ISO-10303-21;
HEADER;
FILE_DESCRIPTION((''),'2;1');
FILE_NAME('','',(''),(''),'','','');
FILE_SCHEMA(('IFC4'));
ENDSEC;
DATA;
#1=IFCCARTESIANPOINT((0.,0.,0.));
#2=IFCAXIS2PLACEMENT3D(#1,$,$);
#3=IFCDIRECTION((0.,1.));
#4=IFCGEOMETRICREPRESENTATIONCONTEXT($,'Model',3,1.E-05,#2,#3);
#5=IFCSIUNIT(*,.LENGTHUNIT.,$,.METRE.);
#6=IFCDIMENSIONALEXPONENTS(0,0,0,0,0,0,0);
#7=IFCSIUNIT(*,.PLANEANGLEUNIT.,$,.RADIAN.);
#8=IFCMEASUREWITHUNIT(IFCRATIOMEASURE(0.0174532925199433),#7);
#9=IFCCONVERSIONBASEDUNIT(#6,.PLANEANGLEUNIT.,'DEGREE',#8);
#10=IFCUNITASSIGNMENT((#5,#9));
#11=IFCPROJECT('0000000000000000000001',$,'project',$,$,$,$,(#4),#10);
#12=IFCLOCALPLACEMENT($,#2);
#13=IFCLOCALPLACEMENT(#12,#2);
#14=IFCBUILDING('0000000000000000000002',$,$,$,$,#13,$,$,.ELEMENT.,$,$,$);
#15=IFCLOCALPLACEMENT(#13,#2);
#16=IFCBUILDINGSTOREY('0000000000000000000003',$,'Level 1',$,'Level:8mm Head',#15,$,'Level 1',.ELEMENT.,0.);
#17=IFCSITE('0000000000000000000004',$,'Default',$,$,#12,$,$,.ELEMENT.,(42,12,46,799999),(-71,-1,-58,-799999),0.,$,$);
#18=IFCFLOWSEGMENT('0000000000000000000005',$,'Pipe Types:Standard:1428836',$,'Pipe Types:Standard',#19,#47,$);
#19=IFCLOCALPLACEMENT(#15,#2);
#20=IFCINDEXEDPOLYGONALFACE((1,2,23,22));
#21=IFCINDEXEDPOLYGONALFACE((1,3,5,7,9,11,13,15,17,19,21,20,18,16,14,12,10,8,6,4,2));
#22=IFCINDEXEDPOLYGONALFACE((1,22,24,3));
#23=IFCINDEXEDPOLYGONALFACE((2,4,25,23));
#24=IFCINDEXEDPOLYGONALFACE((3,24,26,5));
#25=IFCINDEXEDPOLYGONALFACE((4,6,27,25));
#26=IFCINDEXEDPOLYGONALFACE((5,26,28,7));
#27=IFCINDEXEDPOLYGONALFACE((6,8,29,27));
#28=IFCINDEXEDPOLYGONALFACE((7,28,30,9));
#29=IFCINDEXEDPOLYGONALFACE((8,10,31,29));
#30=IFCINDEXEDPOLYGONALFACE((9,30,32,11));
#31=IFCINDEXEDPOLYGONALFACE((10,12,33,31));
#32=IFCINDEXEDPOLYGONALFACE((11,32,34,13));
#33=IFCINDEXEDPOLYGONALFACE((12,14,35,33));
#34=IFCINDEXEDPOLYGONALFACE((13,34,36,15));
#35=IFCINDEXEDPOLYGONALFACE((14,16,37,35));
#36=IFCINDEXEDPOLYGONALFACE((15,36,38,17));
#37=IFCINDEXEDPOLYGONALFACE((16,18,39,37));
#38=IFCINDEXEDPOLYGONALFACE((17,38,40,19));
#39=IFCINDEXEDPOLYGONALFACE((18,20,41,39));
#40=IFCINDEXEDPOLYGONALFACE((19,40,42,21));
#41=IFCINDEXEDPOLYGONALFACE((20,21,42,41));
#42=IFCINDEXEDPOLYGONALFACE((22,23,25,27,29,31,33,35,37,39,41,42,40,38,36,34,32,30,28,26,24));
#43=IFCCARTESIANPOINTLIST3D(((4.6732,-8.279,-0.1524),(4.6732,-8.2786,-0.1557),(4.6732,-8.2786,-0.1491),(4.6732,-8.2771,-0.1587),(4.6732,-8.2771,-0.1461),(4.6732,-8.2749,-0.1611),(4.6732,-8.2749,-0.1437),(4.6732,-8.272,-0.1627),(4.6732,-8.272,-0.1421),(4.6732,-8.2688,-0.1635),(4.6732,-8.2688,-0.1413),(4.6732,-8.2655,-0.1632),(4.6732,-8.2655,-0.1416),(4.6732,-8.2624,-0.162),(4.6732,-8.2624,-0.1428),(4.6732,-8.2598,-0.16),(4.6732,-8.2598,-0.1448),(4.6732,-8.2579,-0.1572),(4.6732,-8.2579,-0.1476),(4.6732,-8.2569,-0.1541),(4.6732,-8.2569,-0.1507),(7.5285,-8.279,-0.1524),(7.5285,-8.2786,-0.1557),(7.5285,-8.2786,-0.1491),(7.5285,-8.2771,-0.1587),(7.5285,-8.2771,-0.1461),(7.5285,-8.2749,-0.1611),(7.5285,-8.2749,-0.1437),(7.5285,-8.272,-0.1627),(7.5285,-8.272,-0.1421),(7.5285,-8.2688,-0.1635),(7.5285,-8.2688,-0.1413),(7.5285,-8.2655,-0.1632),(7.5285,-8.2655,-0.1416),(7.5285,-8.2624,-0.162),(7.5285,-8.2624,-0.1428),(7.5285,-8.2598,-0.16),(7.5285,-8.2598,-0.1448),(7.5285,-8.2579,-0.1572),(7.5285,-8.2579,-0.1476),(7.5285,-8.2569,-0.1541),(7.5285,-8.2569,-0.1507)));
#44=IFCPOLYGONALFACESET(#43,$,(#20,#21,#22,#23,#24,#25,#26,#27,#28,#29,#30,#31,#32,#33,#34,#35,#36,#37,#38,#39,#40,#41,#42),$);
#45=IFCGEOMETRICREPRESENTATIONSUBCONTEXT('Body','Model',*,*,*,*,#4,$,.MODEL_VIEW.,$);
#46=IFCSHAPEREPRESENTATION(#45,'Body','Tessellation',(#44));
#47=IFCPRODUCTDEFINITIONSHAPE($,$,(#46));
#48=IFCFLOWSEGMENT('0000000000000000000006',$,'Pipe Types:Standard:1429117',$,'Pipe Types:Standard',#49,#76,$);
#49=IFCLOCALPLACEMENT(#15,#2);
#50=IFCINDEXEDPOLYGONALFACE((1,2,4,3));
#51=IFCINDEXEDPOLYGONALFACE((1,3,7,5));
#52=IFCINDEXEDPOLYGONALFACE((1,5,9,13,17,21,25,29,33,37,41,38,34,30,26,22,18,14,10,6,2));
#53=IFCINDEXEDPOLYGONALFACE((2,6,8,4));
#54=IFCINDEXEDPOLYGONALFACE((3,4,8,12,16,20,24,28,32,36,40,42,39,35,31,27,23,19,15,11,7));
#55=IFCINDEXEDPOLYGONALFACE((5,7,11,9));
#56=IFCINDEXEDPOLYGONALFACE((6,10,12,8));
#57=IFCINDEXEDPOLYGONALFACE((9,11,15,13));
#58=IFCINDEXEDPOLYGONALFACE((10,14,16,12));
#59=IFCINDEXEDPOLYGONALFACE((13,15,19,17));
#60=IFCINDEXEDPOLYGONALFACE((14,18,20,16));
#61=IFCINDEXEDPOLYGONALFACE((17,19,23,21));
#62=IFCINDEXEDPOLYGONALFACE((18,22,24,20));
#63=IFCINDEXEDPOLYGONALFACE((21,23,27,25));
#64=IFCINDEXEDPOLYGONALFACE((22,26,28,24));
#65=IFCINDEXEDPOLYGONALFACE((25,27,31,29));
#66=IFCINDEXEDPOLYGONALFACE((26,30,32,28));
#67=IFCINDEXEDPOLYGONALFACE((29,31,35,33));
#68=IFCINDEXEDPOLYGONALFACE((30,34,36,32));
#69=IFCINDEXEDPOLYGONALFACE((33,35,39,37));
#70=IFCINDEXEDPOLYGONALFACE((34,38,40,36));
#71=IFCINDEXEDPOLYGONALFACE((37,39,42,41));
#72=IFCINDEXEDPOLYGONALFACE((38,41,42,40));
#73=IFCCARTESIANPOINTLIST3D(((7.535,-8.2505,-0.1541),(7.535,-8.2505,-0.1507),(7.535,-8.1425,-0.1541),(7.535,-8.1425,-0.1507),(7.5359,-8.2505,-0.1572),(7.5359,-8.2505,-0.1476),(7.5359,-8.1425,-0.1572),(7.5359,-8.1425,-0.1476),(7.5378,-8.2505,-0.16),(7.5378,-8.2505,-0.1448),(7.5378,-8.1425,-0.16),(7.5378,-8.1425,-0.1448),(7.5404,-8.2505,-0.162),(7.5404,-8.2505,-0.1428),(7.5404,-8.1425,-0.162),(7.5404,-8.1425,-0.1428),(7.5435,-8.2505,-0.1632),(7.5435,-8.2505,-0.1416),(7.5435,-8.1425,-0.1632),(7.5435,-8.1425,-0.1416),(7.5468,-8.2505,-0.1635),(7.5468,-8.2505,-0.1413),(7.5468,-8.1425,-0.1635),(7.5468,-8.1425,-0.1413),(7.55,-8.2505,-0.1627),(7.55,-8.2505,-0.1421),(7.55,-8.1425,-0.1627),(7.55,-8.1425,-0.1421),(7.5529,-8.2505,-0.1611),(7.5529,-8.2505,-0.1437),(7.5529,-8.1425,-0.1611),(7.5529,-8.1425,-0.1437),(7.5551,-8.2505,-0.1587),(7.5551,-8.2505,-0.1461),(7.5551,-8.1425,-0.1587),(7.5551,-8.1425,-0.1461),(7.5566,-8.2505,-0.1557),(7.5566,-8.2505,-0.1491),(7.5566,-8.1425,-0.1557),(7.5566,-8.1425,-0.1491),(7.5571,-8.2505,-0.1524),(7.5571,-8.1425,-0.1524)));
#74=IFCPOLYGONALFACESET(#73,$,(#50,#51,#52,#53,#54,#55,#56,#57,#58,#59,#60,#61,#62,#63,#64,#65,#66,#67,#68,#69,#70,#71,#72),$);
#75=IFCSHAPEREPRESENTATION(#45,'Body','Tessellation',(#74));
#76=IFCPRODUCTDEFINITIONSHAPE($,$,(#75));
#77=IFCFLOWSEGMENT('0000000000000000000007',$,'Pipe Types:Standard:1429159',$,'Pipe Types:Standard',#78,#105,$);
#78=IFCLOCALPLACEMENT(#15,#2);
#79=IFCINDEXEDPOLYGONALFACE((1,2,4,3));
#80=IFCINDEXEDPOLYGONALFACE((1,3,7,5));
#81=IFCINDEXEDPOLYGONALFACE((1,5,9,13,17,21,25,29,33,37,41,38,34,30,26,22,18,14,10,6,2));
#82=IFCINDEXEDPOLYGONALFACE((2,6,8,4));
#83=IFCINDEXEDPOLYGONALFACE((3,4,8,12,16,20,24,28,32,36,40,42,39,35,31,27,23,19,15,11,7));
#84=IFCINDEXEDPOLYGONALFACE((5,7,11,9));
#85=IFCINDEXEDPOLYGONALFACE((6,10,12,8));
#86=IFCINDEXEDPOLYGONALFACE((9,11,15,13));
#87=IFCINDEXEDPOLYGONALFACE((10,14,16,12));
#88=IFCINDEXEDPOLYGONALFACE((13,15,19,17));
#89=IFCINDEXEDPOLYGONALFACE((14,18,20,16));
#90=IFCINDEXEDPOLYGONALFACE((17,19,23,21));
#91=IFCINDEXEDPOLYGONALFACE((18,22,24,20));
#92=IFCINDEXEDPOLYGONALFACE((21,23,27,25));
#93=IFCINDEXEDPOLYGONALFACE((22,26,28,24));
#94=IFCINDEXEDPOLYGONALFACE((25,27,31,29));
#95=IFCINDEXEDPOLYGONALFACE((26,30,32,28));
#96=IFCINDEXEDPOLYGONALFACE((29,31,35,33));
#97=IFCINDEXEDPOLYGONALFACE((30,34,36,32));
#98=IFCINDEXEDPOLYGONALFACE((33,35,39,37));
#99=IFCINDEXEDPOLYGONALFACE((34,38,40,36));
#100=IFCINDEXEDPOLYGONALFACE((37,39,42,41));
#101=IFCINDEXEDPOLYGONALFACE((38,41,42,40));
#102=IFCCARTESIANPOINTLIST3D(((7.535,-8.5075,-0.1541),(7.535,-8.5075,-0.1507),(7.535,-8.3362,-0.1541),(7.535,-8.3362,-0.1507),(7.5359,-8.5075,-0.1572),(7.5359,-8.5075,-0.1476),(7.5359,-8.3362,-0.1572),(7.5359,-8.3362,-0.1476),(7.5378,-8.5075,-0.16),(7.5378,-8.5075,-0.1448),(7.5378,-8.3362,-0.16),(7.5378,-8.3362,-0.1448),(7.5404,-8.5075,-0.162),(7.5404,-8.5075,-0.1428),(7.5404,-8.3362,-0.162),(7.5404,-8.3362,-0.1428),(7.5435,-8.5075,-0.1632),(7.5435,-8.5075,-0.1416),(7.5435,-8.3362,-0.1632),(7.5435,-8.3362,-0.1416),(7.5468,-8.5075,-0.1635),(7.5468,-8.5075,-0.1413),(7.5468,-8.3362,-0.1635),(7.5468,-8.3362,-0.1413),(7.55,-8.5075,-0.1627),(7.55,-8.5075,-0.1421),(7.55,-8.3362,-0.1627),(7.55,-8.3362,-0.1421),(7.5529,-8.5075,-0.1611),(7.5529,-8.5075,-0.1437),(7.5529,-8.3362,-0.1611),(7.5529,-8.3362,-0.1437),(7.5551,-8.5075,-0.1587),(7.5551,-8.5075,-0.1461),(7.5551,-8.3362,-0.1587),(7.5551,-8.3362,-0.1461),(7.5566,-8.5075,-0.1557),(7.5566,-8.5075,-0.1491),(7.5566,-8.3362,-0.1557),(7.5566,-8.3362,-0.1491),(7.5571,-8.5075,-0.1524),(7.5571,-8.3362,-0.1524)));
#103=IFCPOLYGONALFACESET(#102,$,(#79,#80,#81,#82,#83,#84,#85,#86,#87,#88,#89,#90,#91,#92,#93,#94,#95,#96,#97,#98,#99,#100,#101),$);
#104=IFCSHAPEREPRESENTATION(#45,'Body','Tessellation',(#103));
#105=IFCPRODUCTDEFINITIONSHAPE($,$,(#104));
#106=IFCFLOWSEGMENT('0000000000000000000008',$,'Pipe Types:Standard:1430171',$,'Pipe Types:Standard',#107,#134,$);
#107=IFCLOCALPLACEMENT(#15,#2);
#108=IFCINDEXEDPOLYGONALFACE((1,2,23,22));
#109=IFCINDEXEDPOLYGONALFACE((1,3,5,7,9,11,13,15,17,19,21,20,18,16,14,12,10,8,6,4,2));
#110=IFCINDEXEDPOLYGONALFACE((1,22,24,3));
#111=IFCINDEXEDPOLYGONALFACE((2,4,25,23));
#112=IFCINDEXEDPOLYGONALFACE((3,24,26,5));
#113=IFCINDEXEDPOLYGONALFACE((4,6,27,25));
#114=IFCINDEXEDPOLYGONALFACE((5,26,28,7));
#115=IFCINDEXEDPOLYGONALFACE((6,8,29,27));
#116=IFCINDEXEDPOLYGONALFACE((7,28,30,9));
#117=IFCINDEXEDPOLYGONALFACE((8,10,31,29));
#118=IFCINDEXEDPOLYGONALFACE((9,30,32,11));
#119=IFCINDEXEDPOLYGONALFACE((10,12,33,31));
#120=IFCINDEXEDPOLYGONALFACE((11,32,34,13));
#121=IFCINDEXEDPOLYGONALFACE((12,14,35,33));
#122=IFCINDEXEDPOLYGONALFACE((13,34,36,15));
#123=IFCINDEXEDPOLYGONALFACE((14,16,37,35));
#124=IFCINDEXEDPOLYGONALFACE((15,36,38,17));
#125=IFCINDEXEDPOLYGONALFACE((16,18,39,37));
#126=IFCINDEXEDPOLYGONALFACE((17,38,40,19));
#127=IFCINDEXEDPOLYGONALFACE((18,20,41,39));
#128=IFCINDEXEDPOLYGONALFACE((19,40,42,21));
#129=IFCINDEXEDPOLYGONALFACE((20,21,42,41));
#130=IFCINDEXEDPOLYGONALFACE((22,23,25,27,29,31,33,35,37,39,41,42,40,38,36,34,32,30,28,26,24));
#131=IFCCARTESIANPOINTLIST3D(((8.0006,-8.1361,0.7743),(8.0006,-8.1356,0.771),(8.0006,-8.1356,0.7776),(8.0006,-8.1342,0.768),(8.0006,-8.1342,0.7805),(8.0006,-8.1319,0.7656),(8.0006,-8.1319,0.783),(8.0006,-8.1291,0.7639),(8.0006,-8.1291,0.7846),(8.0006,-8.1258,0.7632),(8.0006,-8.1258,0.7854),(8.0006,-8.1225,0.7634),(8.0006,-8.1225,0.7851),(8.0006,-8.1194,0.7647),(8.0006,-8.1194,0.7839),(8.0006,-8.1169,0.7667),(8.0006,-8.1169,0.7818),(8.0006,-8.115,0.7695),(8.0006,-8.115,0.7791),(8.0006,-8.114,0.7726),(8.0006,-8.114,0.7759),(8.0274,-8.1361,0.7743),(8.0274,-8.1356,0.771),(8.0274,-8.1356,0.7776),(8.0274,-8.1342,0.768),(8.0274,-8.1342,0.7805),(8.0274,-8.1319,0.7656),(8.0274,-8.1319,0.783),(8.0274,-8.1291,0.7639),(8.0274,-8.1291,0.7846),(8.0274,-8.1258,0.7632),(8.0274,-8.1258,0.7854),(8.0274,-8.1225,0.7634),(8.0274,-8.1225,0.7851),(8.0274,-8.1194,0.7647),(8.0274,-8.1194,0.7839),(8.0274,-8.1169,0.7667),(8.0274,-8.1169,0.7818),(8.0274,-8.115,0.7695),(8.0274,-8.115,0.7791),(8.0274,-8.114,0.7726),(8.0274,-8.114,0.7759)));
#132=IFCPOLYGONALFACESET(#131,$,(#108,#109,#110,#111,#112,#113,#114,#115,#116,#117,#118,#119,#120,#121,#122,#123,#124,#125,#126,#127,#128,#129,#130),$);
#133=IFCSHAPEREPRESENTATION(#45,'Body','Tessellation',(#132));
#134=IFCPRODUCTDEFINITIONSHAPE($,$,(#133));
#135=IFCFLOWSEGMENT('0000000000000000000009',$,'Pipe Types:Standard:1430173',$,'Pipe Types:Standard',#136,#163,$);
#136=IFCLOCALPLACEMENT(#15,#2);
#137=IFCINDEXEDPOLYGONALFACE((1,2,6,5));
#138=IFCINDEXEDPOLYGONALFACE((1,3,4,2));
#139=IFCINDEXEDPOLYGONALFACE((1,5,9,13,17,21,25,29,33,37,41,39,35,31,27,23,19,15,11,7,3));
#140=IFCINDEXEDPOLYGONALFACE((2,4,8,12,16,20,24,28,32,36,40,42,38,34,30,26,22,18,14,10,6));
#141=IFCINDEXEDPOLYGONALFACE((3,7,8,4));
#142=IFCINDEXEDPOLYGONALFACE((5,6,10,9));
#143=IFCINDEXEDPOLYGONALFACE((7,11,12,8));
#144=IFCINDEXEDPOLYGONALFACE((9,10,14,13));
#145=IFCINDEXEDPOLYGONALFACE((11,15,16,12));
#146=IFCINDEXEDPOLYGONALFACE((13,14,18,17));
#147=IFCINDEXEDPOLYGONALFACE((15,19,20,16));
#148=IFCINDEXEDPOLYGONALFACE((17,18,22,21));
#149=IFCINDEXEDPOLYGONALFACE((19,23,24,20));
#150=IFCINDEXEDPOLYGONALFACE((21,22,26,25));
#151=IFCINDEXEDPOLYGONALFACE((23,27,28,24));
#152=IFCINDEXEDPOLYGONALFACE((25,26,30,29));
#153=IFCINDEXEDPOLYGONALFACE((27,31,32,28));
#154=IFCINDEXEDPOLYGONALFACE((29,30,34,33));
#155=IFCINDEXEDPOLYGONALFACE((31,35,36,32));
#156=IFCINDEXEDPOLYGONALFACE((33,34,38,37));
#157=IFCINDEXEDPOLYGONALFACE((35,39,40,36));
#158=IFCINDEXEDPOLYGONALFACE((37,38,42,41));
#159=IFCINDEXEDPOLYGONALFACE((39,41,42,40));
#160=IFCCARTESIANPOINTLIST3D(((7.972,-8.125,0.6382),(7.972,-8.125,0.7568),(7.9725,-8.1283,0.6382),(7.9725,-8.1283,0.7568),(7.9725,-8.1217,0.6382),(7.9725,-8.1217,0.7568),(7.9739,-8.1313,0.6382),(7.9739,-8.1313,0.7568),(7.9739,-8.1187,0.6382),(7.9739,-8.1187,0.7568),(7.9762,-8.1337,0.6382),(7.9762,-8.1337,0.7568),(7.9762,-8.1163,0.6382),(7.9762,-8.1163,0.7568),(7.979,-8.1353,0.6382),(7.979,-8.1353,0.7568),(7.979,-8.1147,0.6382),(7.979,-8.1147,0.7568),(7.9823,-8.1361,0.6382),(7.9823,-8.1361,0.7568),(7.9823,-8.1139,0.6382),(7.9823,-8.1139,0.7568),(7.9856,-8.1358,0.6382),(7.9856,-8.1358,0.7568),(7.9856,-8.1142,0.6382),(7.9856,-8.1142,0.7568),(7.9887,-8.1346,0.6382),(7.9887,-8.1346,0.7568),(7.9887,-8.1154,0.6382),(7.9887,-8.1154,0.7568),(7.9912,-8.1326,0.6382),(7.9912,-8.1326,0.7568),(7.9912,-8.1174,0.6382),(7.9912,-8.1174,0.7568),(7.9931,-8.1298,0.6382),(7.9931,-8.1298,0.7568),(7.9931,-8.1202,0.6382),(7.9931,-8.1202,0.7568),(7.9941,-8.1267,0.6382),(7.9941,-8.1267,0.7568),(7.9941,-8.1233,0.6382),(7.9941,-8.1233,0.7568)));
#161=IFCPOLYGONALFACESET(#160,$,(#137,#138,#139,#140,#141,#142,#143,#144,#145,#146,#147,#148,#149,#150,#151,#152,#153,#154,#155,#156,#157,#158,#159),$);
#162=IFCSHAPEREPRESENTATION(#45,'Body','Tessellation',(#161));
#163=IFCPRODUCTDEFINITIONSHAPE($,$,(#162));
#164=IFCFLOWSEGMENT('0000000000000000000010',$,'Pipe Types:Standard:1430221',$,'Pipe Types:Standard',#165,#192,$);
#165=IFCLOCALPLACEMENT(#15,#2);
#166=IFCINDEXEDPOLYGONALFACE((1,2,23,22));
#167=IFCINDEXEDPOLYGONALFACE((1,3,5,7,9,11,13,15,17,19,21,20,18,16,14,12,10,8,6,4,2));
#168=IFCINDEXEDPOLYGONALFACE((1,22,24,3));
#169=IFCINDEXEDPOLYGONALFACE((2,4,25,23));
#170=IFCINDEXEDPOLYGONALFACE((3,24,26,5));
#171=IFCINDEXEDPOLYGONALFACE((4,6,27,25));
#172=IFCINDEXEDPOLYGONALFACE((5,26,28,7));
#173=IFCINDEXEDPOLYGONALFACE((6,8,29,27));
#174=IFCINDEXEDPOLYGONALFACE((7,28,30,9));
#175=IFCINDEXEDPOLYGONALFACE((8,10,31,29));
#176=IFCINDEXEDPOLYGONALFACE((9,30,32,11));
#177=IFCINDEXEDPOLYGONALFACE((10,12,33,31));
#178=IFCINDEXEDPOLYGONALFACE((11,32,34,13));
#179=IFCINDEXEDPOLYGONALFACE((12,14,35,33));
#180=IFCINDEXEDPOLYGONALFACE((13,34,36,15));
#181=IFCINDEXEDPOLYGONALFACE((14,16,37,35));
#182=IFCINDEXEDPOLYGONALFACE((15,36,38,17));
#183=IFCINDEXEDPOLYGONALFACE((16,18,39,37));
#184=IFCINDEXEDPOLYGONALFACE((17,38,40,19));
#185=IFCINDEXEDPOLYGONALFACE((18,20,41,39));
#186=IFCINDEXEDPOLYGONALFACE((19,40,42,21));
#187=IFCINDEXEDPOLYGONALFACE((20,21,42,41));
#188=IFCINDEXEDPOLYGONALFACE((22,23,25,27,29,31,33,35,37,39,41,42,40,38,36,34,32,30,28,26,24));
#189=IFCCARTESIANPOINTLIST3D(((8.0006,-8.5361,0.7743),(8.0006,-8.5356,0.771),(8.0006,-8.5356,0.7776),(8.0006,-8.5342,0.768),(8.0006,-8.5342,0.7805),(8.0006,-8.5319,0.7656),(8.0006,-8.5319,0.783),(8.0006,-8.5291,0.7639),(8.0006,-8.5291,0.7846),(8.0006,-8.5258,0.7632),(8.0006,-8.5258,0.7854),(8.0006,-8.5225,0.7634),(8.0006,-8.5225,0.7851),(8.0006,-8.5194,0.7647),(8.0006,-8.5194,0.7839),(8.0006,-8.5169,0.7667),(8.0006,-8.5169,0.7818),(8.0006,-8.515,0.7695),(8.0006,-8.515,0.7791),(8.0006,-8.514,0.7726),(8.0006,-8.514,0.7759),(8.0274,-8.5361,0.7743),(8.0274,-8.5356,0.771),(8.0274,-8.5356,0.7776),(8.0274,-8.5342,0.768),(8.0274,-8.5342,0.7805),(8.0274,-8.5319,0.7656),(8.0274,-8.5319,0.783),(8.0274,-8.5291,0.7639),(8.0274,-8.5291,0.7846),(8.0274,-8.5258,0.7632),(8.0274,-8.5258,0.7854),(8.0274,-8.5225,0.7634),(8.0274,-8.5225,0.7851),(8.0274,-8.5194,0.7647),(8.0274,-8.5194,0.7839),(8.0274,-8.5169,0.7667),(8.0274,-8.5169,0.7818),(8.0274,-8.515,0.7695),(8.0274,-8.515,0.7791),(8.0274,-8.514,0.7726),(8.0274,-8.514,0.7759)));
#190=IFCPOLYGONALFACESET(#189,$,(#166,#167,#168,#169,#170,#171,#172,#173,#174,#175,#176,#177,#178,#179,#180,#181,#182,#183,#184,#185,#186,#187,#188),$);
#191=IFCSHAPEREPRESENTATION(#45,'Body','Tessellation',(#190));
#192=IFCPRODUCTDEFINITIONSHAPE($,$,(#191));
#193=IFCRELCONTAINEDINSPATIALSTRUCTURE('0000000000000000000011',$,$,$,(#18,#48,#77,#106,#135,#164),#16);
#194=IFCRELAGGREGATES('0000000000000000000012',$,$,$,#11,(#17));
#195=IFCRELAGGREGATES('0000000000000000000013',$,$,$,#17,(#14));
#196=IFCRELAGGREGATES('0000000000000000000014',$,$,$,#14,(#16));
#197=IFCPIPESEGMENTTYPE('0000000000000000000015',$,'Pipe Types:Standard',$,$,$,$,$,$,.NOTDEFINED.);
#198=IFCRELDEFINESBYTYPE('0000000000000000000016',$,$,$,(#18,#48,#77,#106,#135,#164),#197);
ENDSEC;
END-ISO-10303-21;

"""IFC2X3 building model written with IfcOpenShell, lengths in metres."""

from ifc_helpers import new_model, entity, si_unit, converted_unit, direction, frame, frame_2d, origin, origin_2d_with_axis, place, context, subcontext, project, spatial, circle, extrude, type_object, element, save


model = new_model("IFC2X3")

# Units and contexts
model_context = context("Model", 3, precision=1e-05, world=origin(), true_north=direction((0.0, 1.0)))
body_context = subcontext(model_context, "Body", "Model", "MODEL_VIEW")
ifc_project = project(units=[si_unit("LENGTHUNIT", "METRE"), converted_unit("PLANEANGLEUNIT", "DEGREE", entity("IfcRatioMeasure", 0.0174532925199433), si_unit("PLANEANGLEUNIT", "RADIAN"), dimensions=[0, 0, 0, 0, 0, 0, 0])], contexts=[model_context])

# Site, building, storey
site_placement = place(None, origin())
site = spatial("IfcSite", under=ifc_project, at=site_placement, Name="Default", CompositionType="ELEMENT", RefLatitude=(42, 12, 46, 799999), RefLongitude=(-71, -1, -58, -799999), RefElevation=0.0)
building_placement = place(site_placement, origin())
building = spatial("IfcBuilding", under=site, at=building_placement, CompositionType="ELEMENT")
storey_placement = place(building_placement, origin())
storey = spatial("IfcBuildingStorey", under=building, at=storey_placement, Name="Level 1", ObjectType="Level:8mm Head", LongName="Level 1", CompositionType="ELEMENT", Elevation=0.0)

# Flow segments
pipe_segment_type = type_object("IfcPipeSegmentType", Name="Pipe Types:Standard", PredefinedType="NOTDEFINED")
flow_segment_1_placement = place(storey_placement, origin())
element("IfcFlowSegment", 1, at=flow_segment_1_placement, inside=storey, type_object=pipe_segment_type, Name="Pipe Types:Standard:1428836", ObjectType="Pipe Types:Standard", context=body_context, shape_type="SweptSolid", body=[
    extrude(circle(Radius=0.0111, at=origin_2d_with_axis()), frame((4.6732, -8.2679, -0.1524), z_axis=(1.0, 0.0, 0.0), x_axis=(0.0, -1.0, 0.0)), (0.0, 0.0, 1.0), 2.8553),
])
flow_segment_2_placement = place(storey_placement, origin())
element("IfcFlowSegment", 2, at=flow_segment_2_placement, inside=storey, type_object=pipe_segment_type, Name="Pipe Types:Standard:1429117", ObjectType="Pipe Types:Standard", context=body_context, shape_type="SweptSolid", body=[
    extrude(circle(Radius=0.0111, at=frame_2d((0.0, 0.0), x_axis=(1.0, 0.0))), frame((7.546, -8.2505, -0.1524), z_axis=(0.0, 1.0, 0.0), x_axis=(1.0, 0.0, 0.0)), (0.0, 0.0, 1.0), 0.108),
])
flow_segment_3_placement = place(storey_placement, origin())
element("IfcFlowSegment", 3, at=flow_segment_3_placement, inside=storey, type_object=pipe_segment_type, Name="Pipe Types:Standard:1429159", ObjectType="Pipe Types:Standard", context=body_context, shape_type="SweptSolid", body=[
    extrude(circle(Radius=0.0111, at=origin_2d_with_axis()), frame((7.546, -8.5075, -0.1524), z_axis=(0.0, 1.0, 0.0), x_axis=(1.0, 0.0, 0.0)), (0.0, 0.0, 1.0), 0.1713),
])
flow_segment_4_placement = place(storey_placement, origin())
element("IfcFlowSegment", 4, at=flow_segment_4_placement, inside=storey, type_object=pipe_segment_type, Name="Pipe Types:Standard:1430171", ObjectType="Pipe Types:Standard", context=body_context, shape_type="SweptSolid", body=[
    extrude(circle(Radius=0.0111, at=origin_2d_with_axis()), frame((8.0006, -8.125, 0.7743), z_axis=(1.0, 0.0, 0.0), x_axis=(0.0, -1.0, 0.0)), (0.0, 0.0, 1.0), 0.0269),
])
flow_segment_5_placement = place(storey_placement, origin())
element("IfcFlowSegment", 5, at=flow_segment_5_placement, inside=storey, type_object=pipe_segment_type, Name="Pipe Types:Standard:1430173", ObjectType="Pipe Types:Standard", context=body_context, shape_type="SweptSolid", body=[
    extrude(circle(Radius=0.0111, at=origin_2d_with_axis()), frame((7.9831, -8.125, 0.6382), z_axis=(0.0, 0.0, 1.0), x_axis=(-1.0, 0.0, 0.0)), (0.0, 0.0, 1.0), 0.1186),
])
flow_segment_6_placement = place(storey_placement, origin())
element("IfcFlowSegment", 6, at=flow_segment_6_placement, inside=storey, type_object=pipe_segment_type, Name="Pipe Types:Standard:1430221", ObjectType="Pipe Types:Standard", context=body_context, shape_type="SweptSolid", body=[
    extrude(circle(Radius=0.0111, at=frame_2d((0.0, 0.0), x_axis=(1.0, 0.0))), frame((8.0006, -8.525, 0.7743), z_axis=(1.0, 0.0, 0.0), x_axis=(0.0, -1.0, 0.0)), (0.0, 0.0, 1.0), 0.0269),
])

save(model, "model.ifc")
